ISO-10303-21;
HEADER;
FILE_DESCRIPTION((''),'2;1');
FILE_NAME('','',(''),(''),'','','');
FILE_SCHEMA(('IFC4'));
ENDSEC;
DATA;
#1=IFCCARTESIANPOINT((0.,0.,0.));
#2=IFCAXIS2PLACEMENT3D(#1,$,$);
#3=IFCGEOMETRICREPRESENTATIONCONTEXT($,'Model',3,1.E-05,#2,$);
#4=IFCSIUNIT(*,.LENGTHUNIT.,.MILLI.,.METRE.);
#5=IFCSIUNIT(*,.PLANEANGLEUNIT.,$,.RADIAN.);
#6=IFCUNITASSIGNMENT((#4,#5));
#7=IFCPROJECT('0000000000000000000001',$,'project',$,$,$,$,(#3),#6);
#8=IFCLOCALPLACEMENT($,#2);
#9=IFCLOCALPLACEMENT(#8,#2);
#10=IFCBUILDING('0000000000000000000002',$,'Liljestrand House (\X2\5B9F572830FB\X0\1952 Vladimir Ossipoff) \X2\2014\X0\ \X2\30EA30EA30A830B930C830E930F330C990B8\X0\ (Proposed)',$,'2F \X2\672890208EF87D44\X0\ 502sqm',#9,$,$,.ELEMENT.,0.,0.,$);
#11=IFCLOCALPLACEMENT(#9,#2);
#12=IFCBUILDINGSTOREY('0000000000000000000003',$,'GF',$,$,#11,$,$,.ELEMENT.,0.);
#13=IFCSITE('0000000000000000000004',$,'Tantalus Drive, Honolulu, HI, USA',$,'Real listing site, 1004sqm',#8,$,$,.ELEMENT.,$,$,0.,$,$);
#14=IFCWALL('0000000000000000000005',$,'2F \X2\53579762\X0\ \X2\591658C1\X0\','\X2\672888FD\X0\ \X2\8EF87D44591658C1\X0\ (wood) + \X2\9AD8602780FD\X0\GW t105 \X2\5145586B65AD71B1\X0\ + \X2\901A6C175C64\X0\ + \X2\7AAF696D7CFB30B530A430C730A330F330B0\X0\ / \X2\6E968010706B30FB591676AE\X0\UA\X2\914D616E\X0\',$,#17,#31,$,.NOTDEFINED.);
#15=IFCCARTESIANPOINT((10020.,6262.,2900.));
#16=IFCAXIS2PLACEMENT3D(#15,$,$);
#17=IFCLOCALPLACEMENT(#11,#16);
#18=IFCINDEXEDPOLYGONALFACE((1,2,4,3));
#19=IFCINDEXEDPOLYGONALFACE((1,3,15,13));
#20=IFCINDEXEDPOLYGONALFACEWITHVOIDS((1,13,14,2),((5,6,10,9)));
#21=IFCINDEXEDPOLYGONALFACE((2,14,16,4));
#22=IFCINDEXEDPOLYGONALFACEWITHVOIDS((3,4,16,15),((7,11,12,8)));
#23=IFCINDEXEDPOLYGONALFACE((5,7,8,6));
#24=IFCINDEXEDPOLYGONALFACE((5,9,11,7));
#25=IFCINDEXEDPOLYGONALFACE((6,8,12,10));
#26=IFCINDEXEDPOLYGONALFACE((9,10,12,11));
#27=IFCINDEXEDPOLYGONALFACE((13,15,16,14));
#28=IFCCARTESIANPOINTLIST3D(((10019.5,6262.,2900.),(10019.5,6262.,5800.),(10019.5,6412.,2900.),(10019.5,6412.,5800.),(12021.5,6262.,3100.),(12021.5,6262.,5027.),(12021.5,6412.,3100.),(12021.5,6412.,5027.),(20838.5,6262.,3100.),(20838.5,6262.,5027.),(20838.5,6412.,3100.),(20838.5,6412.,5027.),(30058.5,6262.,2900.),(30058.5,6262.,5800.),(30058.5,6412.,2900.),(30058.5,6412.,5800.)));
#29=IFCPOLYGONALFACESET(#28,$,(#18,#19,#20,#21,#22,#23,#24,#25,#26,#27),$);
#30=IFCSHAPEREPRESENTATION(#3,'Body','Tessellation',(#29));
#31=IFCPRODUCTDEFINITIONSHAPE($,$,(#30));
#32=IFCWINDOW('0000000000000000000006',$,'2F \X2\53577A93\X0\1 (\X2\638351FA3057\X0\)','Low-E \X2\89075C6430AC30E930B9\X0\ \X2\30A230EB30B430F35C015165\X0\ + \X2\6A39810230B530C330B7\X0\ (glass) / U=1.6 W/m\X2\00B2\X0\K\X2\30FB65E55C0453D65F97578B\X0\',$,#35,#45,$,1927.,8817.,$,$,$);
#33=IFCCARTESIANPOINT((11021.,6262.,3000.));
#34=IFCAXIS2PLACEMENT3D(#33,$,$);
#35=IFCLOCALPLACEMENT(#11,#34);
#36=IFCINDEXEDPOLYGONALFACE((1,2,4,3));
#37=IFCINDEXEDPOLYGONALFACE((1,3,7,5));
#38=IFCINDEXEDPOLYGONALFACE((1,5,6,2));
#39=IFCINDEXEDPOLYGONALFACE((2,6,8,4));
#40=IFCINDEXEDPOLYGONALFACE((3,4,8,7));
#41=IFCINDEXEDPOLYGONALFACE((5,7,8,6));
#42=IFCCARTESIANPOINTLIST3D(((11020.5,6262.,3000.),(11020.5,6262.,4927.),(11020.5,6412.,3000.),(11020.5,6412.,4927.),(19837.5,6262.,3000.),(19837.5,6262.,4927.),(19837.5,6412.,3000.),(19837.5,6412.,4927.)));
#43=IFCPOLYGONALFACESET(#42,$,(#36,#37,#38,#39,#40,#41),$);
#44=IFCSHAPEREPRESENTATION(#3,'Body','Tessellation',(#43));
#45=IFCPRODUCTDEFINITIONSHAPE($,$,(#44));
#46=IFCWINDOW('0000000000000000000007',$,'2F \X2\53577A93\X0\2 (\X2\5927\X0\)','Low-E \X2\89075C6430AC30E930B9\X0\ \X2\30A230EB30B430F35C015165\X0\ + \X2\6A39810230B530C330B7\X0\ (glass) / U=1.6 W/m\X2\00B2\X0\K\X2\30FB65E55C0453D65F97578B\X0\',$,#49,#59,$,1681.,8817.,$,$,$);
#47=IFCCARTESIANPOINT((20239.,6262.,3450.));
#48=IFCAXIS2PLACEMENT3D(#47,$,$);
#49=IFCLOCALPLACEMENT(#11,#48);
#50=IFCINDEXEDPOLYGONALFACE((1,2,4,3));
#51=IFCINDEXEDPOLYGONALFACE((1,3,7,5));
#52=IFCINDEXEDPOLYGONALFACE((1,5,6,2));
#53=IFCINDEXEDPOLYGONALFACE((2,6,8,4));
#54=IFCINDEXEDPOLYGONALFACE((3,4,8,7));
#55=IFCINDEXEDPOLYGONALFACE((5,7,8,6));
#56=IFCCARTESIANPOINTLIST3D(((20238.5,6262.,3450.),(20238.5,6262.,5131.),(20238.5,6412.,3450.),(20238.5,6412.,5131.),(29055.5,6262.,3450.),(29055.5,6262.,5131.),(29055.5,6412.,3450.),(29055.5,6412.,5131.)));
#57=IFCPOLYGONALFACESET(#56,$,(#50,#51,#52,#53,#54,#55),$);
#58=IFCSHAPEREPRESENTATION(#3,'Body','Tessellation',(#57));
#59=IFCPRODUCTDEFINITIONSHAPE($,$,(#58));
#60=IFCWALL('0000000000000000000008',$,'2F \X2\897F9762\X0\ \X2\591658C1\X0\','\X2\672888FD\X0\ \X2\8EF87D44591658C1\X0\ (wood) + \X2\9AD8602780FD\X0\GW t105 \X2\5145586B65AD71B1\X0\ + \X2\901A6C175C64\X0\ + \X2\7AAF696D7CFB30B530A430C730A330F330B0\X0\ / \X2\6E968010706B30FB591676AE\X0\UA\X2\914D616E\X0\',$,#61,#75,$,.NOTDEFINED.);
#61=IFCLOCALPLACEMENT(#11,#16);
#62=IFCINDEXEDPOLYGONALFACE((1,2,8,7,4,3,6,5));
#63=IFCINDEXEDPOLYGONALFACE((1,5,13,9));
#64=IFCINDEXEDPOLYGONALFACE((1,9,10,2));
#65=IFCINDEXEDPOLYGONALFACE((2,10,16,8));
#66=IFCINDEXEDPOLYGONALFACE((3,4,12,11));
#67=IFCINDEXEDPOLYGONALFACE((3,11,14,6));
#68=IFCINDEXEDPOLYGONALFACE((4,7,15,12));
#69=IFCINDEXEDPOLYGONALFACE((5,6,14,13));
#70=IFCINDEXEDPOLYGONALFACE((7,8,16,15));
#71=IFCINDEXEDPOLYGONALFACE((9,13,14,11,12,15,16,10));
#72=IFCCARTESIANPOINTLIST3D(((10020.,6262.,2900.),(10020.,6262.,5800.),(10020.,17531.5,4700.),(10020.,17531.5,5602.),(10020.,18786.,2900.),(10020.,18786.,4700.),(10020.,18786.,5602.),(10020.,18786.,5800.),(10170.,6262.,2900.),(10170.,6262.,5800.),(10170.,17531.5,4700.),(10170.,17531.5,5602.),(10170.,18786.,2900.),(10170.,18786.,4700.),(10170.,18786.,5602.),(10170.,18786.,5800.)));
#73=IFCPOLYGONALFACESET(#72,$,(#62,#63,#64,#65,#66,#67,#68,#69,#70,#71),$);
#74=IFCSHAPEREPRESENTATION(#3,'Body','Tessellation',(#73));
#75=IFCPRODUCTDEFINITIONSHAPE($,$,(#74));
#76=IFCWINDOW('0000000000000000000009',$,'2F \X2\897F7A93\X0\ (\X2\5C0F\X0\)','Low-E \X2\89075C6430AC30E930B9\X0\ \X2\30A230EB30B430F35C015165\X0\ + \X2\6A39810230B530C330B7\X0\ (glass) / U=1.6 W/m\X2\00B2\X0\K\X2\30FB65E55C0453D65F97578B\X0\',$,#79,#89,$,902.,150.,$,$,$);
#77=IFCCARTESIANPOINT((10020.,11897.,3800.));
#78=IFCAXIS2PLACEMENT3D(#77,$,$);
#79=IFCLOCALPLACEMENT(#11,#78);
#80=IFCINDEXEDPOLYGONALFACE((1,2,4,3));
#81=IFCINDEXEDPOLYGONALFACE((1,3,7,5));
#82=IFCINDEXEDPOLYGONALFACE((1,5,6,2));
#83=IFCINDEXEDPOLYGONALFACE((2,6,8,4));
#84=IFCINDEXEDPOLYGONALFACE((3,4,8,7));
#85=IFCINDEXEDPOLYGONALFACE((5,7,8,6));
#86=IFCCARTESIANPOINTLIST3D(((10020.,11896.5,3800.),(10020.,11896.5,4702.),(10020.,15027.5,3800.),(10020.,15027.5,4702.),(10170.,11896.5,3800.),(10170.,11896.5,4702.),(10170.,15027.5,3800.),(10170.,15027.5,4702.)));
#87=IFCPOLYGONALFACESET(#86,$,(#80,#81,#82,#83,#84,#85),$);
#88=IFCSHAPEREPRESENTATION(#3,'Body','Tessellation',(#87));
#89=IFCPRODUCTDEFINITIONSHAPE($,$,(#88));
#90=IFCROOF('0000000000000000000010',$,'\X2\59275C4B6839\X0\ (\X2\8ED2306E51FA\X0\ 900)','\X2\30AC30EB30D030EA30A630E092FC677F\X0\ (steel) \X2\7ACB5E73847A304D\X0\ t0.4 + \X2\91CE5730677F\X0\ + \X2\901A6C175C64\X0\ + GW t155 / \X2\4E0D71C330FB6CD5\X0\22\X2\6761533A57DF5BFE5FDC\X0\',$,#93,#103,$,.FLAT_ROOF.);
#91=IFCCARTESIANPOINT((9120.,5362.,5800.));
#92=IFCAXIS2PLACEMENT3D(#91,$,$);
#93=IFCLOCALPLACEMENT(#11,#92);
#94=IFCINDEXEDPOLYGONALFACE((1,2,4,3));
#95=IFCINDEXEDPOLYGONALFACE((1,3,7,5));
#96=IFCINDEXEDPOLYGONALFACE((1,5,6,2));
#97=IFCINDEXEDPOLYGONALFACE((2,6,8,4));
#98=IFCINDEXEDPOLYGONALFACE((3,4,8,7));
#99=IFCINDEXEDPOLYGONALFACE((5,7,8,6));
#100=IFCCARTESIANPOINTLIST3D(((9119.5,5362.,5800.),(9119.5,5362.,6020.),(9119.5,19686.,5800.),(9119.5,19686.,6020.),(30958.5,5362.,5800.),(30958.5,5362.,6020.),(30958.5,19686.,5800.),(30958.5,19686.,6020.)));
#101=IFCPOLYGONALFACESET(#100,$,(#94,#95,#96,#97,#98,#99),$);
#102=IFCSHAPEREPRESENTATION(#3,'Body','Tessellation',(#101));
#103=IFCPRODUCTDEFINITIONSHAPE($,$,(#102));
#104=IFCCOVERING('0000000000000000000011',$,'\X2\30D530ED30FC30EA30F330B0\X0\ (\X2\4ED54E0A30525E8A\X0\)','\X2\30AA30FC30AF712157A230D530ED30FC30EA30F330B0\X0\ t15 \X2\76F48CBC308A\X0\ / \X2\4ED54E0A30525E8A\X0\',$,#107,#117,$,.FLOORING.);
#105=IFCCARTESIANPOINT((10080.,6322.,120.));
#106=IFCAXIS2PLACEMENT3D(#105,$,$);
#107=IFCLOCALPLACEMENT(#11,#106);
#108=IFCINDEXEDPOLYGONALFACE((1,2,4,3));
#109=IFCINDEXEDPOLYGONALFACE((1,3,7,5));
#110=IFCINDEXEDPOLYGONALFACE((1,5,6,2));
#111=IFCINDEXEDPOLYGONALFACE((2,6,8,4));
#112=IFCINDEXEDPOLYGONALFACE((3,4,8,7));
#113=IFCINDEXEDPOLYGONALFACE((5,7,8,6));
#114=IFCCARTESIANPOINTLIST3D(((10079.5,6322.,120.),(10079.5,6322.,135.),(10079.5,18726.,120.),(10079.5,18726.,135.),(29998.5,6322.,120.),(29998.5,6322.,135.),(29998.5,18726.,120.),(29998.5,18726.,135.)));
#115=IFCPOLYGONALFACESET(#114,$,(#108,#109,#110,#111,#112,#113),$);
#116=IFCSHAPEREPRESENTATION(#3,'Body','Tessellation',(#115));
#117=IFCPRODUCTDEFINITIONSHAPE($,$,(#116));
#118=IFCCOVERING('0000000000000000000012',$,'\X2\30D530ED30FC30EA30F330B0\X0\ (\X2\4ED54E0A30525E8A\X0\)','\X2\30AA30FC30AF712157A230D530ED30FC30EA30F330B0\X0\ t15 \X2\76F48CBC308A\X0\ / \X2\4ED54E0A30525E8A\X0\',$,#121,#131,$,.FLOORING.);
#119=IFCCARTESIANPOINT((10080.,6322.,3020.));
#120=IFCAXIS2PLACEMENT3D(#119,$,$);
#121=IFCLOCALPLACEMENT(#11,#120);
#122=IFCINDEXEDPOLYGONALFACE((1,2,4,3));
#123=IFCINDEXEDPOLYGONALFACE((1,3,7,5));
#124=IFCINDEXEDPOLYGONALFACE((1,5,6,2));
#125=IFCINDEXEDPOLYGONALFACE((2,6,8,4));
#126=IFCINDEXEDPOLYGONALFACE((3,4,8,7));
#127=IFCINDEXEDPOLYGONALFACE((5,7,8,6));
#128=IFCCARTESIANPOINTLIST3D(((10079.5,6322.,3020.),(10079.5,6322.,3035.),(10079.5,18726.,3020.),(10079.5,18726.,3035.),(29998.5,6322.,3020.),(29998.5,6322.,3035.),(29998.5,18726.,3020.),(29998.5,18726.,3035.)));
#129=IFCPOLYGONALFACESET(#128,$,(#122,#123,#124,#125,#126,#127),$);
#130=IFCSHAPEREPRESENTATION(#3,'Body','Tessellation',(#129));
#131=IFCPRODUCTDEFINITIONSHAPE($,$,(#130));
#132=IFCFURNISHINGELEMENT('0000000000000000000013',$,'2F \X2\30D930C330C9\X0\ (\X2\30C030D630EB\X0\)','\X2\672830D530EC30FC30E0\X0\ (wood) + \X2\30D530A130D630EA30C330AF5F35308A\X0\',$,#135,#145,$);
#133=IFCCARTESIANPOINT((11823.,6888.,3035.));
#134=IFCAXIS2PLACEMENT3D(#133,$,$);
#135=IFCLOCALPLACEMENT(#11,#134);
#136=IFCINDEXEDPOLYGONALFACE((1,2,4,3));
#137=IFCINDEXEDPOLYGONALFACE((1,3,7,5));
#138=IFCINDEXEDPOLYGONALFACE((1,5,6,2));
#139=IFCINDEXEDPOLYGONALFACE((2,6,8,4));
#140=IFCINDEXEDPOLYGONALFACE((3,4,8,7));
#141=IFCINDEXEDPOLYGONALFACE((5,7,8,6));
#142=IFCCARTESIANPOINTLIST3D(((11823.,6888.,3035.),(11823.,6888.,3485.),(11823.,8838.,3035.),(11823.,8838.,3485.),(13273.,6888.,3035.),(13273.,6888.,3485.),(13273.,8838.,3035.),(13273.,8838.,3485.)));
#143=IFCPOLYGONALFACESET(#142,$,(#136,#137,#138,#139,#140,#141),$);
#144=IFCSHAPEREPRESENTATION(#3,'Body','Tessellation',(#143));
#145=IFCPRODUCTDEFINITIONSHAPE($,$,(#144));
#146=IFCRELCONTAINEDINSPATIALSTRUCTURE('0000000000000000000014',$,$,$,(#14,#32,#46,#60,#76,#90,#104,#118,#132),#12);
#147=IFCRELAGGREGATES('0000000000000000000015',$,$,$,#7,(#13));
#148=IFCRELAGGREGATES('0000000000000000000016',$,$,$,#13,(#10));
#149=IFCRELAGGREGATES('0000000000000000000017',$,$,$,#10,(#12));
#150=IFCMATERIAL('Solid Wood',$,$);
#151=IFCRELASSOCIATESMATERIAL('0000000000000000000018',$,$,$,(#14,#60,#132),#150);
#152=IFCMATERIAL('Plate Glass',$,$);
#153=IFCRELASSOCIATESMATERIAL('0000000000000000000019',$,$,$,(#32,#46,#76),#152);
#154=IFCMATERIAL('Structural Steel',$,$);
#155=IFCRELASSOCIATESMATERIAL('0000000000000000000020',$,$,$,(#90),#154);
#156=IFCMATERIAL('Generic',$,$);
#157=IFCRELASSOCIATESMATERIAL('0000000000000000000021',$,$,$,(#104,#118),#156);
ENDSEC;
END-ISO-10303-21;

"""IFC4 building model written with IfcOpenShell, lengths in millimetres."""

from ifc_helpers import new_model, si_unit, frame, frame_2d, origin, place, context, project, spatial, rectangle, extrude, material, element, fill, save


model = new_model("IFC4")

# Units and contexts
model_context = context("Model", 3, precision=1e-05, world=origin())
ifc_project = project(units=[si_unit("LENGTHUNIT", "METRE", prefix="MILLI"), si_unit("PLANEANGLEUNIT", "RADIAN")], contexts=[model_context])

# Site, building, storey
site_placement = place(None, origin())
site = spatial("IfcSite", under=ifc_project, at=site_placement, Name="Tantalus Drive, Honolulu, HI, USA", ObjectType="Real listing site, 1004sqm", CompositionType="ELEMENT", RefElevation=0.0)
building_placement = place(site_placement, origin())
building = spatial("IfcBuilding", under=site, at=building_placement, Name="Liljestrand House (実在・1952 Vladimir Ossipoff) — リリエストランド邸 (Proposed)", ObjectType="2F 木造軸組 502sqm", CompositionType="ELEMENT", ElevationOfRefHeight=0.0, ElevationOfTerrain=0.0)
storey_placement = place(building_placement, origin())
storey = spatial("IfcBuildingStorey", under=building, at=storey_placement, Name="GF", CompositionType="ELEMENT", Elevation=0.0)

# Shared definitions
ifc_material_1 = material(Name="Solid Wood")

# Shared definitions
ifc_material_2 = material(Name="Plate Glass")

# Wall, openings, windows
wall_1_placement = place(storey_placement, frame((10020.0, 6262.0, 2900.0)))
wall_1 = element("IfcWall", 1, at=wall_1_placement, inside=storey, material=ifc_material_1, Name="2F 南面 外壁", Description="木製 軸組外壁 (wood) + 高性能GW t105 充填断熱 + 通気層 + 窯業系サイディング / 準耐火・外皮UA配慮", PredefinedType="NOTDEFINED", context=model_context, shape_type="SweptSolid", body=[
    extrude(rectangle(XDim=20039.0, YDim=150.0, at=frame_2d((10019.0, 75.0))), frame((10020.0, 6262.0, 2900.0)), (0.0, 0.0, 1.0), 2900.0),
])
opening_1_placement = place(storey_placement, frame((11021.0, 6262.0, 3000.0)))
opening_1 = element("IfcOpeningElement", 2, at=opening_1_placement, cuts=wall_1, PredefinedType="NOTDEFINED", context=model_context, shape_type="SweptSolid", body=[
    extrude(rectangle(XDim=8817.0, YDim=150.0, at=frame_2d((4408.0, 75.0))), frame((11021.0, 6262.0, 3000.0)), (0.0, 0.0, 1.0), 1927.0),
])
opening_2_placement = place(storey_placement, frame((20239.0, 6262.0, 3450.0)))
opening_2 = element("IfcOpeningElement", 3, at=opening_2_placement, cuts=wall_1, PredefinedType="NOTDEFINED", context=model_context, shape_type="SweptSolid", body=[
    extrude(rectangle(XDim=8817.0, YDim=150.0, at=frame_2d((4408.0, 75.0))), frame((20239.0, 6262.0, 3450.0)), (0.0, 0.0, 1.0), 1681.0),
])
window_1_placement = place(storey_placement, frame((11021.0, 6262.0, 3000.0)))
window_1 = element("IfcWindow", 4, at=window_1_placement, inside=storey, material=ifc_material_2, Name="2F 南窓1 (掃出し)", Description="Low-E 複層ガラス アルゴン封入 + 樹脂サッシ (glass) / U=1.6 W/m²K・日射取得型", OverallHeight=1927.0, OverallWidth=8817.0, context=model_context, shape_type="SweptSolid", body=[
    extrude(rectangle(XDim=8817.0, YDim=150.0, at=frame_2d((4408.0, 75.0))), frame((11021.0, 6262.0, 3000.0)), (0.0, 0.0, 1.0), 1927.0),
])
fill(opening_1, window_1)
window_2_placement = place(storey_placement, frame((20239.0, 6262.0, 3450.0)))
window_2 = element("IfcWindow", 5, at=window_2_placement, inside=storey, material=ifc_material_2, Name="2F 南窓2 (大)", Description="Low-E 複層ガラス アルゴン封入 + 樹脂サッシ (glass) / U=1.6 W/m²K・日射取得型", OverallHeight=1681.0, OverallWidth=8817.0, context=model_context, shape_type="SweptSolid", body=[
    extrude(rectangle(XDim=8817.0, YDim=150.0, at=frame_2d((4408.0, 75.0))), frame((20239.0, 6262.0, 3450.0)), (0.0, 0.0, 1.0), 1681.0),
])
fill(opening_2, window_2)

# Wall, opening, window
wall_2_placement = place(storey_placement, frame((10020.0, 6262.0, 2900.0)))
wall_2 = element("IfcWall", 6, at=wall_2_placement, inside=storey, material=ifc_material_1, Name="2F 西面 外壁", Description="木製 軸組外壁 (wood) + 高性能GW t105 充填断熱 + 通気層 + 窯業系サイディング / 準耐火・外皮UA配慮", PredefinedType="NOTDEFINED", context=model_context, shape_type="SweptSolid", body=[
    extrude(rectangle(XDim=150.0, YDim=12524.0, at=frame_2d((75.0, 6262.0))), frame((10020.0, 6262.0, 2900.0)), (0.0, 0.0, 1.0), 2900.0),
])
opening_3_placement = place(storey_placement, frame((10020.0, 11897.0, 3800.0)))
opening_3 = element("IfcOpeningElement", 7, at=opening_3_placement, cuts=wall_2, PredefinedType="NOTDEFINED", context=model_context, shape_type="SweptSolid", body=[
    extrude(rectangle(XDim=150.0, YDim=3131.0, at=frame_2d((75.0, 1565.0))), frame((10020.0, 11897.0, 3800.0)), (0.0, 0.0, 1.0), 902.0),
])
window_3_placement = place(storey_placement, frame((10020.0, 11897.0, 3800.0)))
window_3 = element("IfcWindow", 8, at=window_3_placement, inside=storey, material=ifc_material_2, Name="2F 西窓 (小)", Description="Low-E 複層ガラス アルゴン封入 + 樹脂サッシ (glass) / U=1.6 W/m²K・日射取得型", OverallHeight=902.0, OverallWidth=150.0, context=model_context, shape_type="SweptSolid", body=[
    extrude(rectangle(XDim=150.0, YDim=3131.0, at=frame_2d((75.0, 1565.0))), frame((10020.0, 11897.0, 3800.0)), (0.0, 0.0, 1.0), 902.0),
])
fill(opening_3, window_3)

# Roof
ifc_material_3 = material(Name="Structural Steel")
roof_placement = place(storey_placement, frame((9120.0, 5362.0, 5800.0)))
element("IfcRoof", 9, at=roof_placement, inside=storey, material=ifc_material_3, Name="大屋根 (軒の出 900)", Description="ガルバリウム鋼板 (steel) 立平葺き t0.4 + 野地板 + 通気層 + GW t155 / 不燃・法22条区域対応", PredefinedType="FLAT_ROOF", context=model_context, shape_type="SweptSolid", body=[
    extrude(rectangle(XDim=21839.0, YDim=14324.0, at=frame_2d((10919.0, 7162.0))), frame((9120.0, 5362.0, 5800.0)), (0.0, 0.0, 1.0), 220.0),
])

# Coverings
ifc_material_4 = material(Name="Generic")
covering_1_placement = place(storey_placement, frame((10080.0, 6322.0, 120.0)))
element("IfcCovering", 10, at=covering_1_placement, inside=storey, material=ifc_material_4, Name="フローリング (仕上げ床)", Description="オーク無垢フローリング t15 直貼り / 仕上げ床", PredefinedType="FLOORING", context=model_context, shape_type="SweptSolid", body=[
    extrude(rectangle(XDim=19919.0, YDim=12404.0, at=frame_2d((9959.0, 6202.0))), frame((10080.0, 6322.0, 120.0)), (0.0, 0.0, 1.0), 15.0),
])
covering_2_placement = place(storey_placement, frame((10080.0, 6322.0, 3020.0)))
element("IfcCovering", 11, at=covering_2_placement, inside=storey, material=ifc_material_4, Name="フローリング (仕上げ床)", Description="オーク無垢フローリング t15 直貼り / 仕上げ床", PredefinedType="FLOORING", context=model_context, shape_type="SweptSolid", body=[
    extrude(rectangle(XDim=19919.0, YDim=12404.0, at=frame_2d((9959.0, 6202.0))), frame((10080.0, 6322.0, 3020.0)), (0.0, 0.0, 1.0), 15.0),
])

# Furnishing element
furnishing_placement = place(storey_placement, frame((11823.0, 6888.0, 3035.0)))
element("IfcFurnishingElement", 12, at=furnishing_placement, inside=storey, material=ifc_material_1, Name="2F ベッド (ダブル)", Description="木フレーム (wood) + ファブリック張り", context=model_context, shape_type="SweptSolid", body=[
    extrude(rectangle(XDim=1450.0, YDim=1950.0, at=frame_2d((725.0, 975.0))), frame((11823.0, 6888.0, 3035.0)), (0.0, 0.0, 1.0), 450.0),
])

save(model, "model.ifc")
